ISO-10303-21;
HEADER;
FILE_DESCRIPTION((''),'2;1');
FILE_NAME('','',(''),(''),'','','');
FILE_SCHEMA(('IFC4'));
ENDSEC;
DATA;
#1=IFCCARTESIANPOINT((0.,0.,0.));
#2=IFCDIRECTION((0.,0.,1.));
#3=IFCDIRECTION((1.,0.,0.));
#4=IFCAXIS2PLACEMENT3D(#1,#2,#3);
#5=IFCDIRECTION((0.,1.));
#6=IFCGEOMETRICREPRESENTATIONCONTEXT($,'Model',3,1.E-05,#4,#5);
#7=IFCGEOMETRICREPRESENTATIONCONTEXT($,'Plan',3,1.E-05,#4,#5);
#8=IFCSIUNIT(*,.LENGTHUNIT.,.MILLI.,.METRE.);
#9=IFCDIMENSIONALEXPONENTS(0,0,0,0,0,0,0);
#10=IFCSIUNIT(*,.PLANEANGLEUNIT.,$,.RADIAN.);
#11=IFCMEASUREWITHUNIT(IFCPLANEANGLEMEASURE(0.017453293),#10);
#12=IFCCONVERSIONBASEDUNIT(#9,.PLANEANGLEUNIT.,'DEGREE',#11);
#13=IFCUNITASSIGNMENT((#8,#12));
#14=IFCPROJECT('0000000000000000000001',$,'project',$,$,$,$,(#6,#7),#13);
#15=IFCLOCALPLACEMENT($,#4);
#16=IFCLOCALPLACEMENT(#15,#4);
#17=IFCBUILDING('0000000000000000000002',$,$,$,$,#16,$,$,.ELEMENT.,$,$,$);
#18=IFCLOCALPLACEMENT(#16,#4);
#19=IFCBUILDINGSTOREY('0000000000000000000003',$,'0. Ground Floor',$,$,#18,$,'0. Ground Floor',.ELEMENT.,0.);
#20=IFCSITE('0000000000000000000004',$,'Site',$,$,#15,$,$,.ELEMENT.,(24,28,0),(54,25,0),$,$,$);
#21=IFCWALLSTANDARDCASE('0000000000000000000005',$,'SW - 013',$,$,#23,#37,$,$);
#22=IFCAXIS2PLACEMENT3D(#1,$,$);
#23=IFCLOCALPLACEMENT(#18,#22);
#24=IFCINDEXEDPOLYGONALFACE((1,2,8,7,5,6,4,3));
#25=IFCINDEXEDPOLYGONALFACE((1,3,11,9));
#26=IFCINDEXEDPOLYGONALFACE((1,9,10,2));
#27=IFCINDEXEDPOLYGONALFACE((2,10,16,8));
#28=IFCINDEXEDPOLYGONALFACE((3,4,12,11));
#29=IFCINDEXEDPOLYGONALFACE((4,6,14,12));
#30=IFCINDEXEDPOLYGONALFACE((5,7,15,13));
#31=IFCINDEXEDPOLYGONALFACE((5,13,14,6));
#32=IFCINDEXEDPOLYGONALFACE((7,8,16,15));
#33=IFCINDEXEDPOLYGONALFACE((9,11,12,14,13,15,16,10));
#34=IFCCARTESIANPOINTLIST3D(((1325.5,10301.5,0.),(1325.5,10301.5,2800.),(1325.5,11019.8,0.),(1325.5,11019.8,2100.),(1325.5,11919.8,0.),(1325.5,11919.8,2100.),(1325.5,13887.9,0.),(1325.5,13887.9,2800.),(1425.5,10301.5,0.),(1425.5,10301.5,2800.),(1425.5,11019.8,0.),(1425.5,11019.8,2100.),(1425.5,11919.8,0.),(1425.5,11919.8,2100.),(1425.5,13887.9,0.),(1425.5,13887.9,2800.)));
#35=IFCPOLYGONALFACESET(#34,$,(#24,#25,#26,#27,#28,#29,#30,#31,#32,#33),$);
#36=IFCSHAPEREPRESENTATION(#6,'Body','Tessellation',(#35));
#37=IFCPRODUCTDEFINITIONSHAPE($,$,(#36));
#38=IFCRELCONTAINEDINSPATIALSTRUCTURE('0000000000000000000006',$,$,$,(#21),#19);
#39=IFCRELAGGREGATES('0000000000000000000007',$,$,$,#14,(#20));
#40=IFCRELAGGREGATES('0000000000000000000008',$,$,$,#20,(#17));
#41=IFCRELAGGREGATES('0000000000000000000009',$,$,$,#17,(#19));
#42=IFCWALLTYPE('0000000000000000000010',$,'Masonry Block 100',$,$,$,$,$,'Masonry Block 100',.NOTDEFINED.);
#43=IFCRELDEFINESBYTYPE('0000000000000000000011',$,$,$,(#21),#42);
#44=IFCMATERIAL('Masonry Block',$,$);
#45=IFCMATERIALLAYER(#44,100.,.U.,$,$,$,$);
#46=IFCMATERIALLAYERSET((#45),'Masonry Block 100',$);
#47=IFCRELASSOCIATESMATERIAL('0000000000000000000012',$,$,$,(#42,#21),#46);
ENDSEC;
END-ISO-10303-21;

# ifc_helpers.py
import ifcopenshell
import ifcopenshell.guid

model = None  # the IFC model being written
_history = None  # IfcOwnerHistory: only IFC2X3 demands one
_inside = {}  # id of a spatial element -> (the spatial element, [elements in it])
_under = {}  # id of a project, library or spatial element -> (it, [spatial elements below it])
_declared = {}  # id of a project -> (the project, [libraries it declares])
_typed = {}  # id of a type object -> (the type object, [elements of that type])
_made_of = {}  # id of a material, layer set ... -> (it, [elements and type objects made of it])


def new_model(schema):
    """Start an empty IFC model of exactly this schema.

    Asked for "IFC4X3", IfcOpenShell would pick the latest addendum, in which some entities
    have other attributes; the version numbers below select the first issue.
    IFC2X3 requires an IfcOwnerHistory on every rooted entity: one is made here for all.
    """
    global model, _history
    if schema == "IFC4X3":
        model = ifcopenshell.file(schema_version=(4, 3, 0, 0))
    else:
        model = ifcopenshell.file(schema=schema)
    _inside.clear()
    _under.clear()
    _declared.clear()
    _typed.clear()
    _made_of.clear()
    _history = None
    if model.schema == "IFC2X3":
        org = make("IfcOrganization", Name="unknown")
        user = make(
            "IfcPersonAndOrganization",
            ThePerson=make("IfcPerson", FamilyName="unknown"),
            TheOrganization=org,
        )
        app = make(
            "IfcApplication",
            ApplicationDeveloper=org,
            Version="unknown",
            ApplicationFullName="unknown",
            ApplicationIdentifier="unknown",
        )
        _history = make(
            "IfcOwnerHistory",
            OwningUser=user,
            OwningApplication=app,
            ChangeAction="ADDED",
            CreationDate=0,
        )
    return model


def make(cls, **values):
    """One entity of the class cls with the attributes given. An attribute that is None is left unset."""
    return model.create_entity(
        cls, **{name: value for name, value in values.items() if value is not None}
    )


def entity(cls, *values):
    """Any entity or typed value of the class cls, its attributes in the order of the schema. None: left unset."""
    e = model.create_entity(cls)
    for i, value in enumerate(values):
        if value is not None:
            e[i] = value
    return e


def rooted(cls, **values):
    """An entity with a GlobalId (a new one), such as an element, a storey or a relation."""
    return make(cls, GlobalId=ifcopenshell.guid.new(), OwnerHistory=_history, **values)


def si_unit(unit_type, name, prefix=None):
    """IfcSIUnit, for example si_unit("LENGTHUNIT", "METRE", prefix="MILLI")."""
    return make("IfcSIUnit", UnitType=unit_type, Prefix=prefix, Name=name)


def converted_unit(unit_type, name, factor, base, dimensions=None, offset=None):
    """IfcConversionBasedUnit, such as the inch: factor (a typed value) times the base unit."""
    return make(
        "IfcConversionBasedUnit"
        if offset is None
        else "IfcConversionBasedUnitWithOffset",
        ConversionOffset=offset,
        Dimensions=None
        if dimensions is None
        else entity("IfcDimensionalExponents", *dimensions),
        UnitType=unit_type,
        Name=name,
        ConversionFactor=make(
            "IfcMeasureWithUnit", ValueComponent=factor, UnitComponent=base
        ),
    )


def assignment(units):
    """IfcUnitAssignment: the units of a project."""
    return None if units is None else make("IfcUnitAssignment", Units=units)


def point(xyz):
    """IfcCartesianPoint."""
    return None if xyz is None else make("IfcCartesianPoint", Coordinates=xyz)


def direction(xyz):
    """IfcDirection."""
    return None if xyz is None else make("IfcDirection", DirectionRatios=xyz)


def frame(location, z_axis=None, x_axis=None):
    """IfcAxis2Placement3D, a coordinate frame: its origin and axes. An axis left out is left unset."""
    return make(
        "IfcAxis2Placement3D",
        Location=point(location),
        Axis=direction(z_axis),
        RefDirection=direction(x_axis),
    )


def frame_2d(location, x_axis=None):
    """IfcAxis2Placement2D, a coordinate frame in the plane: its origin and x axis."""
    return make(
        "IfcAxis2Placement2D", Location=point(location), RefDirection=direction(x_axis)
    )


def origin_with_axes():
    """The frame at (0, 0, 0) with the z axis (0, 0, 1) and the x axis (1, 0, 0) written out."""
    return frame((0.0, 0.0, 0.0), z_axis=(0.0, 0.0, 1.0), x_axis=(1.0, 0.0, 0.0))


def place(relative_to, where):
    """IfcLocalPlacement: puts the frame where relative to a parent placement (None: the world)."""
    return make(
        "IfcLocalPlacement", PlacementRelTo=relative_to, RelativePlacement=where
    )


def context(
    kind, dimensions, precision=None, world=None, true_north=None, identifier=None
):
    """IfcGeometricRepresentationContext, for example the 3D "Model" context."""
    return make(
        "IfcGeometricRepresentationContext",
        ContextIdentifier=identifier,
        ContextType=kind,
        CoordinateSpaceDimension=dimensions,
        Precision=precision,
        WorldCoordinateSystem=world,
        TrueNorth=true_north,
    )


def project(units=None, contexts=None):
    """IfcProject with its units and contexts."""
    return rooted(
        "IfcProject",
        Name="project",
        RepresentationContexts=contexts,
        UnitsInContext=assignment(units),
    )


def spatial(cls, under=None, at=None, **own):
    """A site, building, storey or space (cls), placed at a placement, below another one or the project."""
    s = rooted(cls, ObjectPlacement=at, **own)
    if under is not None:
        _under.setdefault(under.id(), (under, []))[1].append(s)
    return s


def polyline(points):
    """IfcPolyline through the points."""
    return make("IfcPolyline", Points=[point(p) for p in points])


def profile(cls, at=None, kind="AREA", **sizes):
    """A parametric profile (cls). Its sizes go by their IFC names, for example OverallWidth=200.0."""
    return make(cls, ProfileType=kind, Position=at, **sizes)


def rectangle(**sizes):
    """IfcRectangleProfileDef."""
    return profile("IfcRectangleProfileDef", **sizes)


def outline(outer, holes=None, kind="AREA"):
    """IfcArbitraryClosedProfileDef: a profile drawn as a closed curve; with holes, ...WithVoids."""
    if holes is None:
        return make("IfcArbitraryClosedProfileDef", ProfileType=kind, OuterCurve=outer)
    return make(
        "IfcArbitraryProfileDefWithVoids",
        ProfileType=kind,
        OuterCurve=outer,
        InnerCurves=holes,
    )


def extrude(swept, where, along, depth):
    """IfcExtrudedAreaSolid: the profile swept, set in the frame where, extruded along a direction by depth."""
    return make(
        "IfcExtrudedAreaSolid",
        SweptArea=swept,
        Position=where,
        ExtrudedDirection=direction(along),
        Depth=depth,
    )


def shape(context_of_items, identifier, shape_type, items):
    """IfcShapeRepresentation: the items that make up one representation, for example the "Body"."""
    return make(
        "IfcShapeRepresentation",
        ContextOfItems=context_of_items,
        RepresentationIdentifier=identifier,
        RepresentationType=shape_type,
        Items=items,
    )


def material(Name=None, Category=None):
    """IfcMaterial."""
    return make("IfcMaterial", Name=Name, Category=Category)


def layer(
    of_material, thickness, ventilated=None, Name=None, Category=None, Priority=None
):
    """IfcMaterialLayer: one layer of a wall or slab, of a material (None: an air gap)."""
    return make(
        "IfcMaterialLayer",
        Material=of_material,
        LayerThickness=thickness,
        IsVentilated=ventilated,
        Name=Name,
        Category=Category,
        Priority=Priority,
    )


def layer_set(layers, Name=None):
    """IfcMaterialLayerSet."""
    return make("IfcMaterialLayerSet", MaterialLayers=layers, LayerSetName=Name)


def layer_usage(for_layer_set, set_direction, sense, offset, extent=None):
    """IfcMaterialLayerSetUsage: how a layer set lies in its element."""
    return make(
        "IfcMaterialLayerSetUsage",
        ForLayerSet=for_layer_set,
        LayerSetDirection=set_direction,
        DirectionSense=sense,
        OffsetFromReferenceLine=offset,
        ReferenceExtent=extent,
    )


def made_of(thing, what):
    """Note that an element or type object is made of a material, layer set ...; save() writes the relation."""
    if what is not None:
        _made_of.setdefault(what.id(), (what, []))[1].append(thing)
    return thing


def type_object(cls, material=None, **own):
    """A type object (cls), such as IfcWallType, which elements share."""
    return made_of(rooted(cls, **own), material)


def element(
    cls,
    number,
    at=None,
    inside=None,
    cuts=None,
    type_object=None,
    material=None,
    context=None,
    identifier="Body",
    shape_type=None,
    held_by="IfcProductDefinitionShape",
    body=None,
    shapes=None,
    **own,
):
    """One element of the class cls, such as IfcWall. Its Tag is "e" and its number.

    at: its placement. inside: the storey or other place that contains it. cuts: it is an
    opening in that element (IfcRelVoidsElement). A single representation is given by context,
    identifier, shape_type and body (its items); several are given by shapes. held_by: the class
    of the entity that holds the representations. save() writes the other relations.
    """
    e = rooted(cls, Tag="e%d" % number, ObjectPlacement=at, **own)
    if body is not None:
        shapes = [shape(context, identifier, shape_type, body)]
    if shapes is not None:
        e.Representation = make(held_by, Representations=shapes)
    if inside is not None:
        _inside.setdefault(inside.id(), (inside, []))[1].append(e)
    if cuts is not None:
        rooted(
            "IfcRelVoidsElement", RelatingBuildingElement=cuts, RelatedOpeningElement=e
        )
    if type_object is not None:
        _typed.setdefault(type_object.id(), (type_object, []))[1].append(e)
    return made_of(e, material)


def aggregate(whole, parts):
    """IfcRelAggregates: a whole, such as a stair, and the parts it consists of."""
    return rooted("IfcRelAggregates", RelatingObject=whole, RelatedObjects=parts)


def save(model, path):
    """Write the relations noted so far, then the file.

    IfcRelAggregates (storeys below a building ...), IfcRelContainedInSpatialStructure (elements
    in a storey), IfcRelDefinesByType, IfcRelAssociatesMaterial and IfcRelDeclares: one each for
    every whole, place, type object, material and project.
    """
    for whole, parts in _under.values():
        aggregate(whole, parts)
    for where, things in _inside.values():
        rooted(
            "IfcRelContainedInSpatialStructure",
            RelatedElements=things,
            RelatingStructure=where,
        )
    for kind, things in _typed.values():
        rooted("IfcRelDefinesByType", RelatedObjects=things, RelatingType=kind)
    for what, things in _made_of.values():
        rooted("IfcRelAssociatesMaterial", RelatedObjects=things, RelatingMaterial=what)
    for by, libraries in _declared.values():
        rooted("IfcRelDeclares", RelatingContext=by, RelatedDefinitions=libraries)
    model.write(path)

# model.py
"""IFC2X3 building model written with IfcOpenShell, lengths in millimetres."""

from ifc_helpers import new_model, entity, si_unit, converted_unit, direction, frame, frame_2d, origin_with_axes, place, context, project, spatial, polyline, rectangle, outline, extrude, material, layer, layer_set, layer_usage, type_object, element, save


model = new_model("IFC2X3")

# Units and contexts
model_context = context("Model", 3, precision=1e-05, world=origin_with_axes(), true_north=direction((0.0, 1.0)))
plan_context = context("Plan", 3, precision=1e-05, world=origin_with_axes(), true_north=direction((0.0, 1.0)))
ifc_project = project(units=[si_unit("LENGTHUNIT", "METRE", prefix="MILLI"), converted_unit("PLANEANGLEUNIT", "DEGREE", entity("IfcPlaneAngleMeasure", 0.017453293), si_unit("PLANEANGLEUNIT", "RADIAN"), dimensions=[0, 0, 0, 0, 0, 0, 0])], contexts=[model_context, plan_context])

# Site, building, storey
site_placement = place(None, origin_with_axes())
site = spatial("IfcSite", under=ifc_project, at=site_placement, Name="Site", CompositionType="ELEMENT", RefLatitude=(24, 28, 0), RefLongitude=(54, 25, 0))
building_placement = place(site_placement, origin_with_axes())
building = spatial("IfcBuilding", under=site, at=building_placement, CompositionType="ELEMENT")
storey_placement = place(building_placement, origin_with_axes())
storey = spatial("IfcBuildingStorey", under=building, at=storey_placement, Name="0. Ground Floor", LongName="0. Ground Floor", CompositionType="ELEMENT", Elevation=0.0)

# Shared definitions
ifc_material_1 = material(Name="Masonry Block")

# Wall, opening
ifc_layer_1 = layer(ifc_material_1, 100.0, ventilated="UNKNOWN")
ifc_layer_set_1 = layer_set([ifc_layer_1], Name="Masonry Block 100")
ifc_layer_usage_1 = layer_usage(ifc_layer_set_1, "AXIS2", "POSITIVE", 0.0)
wall_type_1 = type_object("IfcWallType", Name="Masonry Block 100", ElementType="Masonry Block 100", PredefinedType="NOTDEFINED", material=ifc_layer_set_1)
wall_1_placement = place(storey_placement, frame((1325.5, 13887.9, 0.0), z_axis=(0.0, 0.0, 1.0), x_axis=(0.0, -1.0, 0.0)))
wall_1 = element("IfcWallStandardCase", 1, at=wall_1_placement, inside=storey, type_object=wall_type_1, material=ifc_layer_usage_1, Name="SW - 013", context=model_context, shape_type="SweptSolid", body=[
    extrude(outline(polyline([(0.0, 0.0), (3586.4, 0.0), (3586.4, 100.0), (0.0, 100.0), (0.0, 0.0)])), origin_with_axes(), (0.0, 0.0, 1.0), 2800.0),
])
opening_1_placement = place(wall_1_placement, frame((2418.1, 0.0, 0.0), z_axis=(0.0, 0.0, 1.0), x_axis=(1.0, 0.0, 0.0)))
element("IfcOpeningElement", 2, at=opening_1_placement, cuts=wall_1, ObjectType="Opening", context=model_context, shape_type="SweptSolid", body=[
    extrude(rectangle(XDim=900.0, YDim=2100.0, at=frame_2d((0.0, 1050.0), x_axis=(-1.0, 0.0))), frame((0.0, 0.0, 0.0), z_axis=(0.0, 1.0, 0.0), x_axis=(-1.0, 0.0, 0.0)), (0.0, 0.0, 1.0), 100.0),
])

save(model, "model.ifc")
